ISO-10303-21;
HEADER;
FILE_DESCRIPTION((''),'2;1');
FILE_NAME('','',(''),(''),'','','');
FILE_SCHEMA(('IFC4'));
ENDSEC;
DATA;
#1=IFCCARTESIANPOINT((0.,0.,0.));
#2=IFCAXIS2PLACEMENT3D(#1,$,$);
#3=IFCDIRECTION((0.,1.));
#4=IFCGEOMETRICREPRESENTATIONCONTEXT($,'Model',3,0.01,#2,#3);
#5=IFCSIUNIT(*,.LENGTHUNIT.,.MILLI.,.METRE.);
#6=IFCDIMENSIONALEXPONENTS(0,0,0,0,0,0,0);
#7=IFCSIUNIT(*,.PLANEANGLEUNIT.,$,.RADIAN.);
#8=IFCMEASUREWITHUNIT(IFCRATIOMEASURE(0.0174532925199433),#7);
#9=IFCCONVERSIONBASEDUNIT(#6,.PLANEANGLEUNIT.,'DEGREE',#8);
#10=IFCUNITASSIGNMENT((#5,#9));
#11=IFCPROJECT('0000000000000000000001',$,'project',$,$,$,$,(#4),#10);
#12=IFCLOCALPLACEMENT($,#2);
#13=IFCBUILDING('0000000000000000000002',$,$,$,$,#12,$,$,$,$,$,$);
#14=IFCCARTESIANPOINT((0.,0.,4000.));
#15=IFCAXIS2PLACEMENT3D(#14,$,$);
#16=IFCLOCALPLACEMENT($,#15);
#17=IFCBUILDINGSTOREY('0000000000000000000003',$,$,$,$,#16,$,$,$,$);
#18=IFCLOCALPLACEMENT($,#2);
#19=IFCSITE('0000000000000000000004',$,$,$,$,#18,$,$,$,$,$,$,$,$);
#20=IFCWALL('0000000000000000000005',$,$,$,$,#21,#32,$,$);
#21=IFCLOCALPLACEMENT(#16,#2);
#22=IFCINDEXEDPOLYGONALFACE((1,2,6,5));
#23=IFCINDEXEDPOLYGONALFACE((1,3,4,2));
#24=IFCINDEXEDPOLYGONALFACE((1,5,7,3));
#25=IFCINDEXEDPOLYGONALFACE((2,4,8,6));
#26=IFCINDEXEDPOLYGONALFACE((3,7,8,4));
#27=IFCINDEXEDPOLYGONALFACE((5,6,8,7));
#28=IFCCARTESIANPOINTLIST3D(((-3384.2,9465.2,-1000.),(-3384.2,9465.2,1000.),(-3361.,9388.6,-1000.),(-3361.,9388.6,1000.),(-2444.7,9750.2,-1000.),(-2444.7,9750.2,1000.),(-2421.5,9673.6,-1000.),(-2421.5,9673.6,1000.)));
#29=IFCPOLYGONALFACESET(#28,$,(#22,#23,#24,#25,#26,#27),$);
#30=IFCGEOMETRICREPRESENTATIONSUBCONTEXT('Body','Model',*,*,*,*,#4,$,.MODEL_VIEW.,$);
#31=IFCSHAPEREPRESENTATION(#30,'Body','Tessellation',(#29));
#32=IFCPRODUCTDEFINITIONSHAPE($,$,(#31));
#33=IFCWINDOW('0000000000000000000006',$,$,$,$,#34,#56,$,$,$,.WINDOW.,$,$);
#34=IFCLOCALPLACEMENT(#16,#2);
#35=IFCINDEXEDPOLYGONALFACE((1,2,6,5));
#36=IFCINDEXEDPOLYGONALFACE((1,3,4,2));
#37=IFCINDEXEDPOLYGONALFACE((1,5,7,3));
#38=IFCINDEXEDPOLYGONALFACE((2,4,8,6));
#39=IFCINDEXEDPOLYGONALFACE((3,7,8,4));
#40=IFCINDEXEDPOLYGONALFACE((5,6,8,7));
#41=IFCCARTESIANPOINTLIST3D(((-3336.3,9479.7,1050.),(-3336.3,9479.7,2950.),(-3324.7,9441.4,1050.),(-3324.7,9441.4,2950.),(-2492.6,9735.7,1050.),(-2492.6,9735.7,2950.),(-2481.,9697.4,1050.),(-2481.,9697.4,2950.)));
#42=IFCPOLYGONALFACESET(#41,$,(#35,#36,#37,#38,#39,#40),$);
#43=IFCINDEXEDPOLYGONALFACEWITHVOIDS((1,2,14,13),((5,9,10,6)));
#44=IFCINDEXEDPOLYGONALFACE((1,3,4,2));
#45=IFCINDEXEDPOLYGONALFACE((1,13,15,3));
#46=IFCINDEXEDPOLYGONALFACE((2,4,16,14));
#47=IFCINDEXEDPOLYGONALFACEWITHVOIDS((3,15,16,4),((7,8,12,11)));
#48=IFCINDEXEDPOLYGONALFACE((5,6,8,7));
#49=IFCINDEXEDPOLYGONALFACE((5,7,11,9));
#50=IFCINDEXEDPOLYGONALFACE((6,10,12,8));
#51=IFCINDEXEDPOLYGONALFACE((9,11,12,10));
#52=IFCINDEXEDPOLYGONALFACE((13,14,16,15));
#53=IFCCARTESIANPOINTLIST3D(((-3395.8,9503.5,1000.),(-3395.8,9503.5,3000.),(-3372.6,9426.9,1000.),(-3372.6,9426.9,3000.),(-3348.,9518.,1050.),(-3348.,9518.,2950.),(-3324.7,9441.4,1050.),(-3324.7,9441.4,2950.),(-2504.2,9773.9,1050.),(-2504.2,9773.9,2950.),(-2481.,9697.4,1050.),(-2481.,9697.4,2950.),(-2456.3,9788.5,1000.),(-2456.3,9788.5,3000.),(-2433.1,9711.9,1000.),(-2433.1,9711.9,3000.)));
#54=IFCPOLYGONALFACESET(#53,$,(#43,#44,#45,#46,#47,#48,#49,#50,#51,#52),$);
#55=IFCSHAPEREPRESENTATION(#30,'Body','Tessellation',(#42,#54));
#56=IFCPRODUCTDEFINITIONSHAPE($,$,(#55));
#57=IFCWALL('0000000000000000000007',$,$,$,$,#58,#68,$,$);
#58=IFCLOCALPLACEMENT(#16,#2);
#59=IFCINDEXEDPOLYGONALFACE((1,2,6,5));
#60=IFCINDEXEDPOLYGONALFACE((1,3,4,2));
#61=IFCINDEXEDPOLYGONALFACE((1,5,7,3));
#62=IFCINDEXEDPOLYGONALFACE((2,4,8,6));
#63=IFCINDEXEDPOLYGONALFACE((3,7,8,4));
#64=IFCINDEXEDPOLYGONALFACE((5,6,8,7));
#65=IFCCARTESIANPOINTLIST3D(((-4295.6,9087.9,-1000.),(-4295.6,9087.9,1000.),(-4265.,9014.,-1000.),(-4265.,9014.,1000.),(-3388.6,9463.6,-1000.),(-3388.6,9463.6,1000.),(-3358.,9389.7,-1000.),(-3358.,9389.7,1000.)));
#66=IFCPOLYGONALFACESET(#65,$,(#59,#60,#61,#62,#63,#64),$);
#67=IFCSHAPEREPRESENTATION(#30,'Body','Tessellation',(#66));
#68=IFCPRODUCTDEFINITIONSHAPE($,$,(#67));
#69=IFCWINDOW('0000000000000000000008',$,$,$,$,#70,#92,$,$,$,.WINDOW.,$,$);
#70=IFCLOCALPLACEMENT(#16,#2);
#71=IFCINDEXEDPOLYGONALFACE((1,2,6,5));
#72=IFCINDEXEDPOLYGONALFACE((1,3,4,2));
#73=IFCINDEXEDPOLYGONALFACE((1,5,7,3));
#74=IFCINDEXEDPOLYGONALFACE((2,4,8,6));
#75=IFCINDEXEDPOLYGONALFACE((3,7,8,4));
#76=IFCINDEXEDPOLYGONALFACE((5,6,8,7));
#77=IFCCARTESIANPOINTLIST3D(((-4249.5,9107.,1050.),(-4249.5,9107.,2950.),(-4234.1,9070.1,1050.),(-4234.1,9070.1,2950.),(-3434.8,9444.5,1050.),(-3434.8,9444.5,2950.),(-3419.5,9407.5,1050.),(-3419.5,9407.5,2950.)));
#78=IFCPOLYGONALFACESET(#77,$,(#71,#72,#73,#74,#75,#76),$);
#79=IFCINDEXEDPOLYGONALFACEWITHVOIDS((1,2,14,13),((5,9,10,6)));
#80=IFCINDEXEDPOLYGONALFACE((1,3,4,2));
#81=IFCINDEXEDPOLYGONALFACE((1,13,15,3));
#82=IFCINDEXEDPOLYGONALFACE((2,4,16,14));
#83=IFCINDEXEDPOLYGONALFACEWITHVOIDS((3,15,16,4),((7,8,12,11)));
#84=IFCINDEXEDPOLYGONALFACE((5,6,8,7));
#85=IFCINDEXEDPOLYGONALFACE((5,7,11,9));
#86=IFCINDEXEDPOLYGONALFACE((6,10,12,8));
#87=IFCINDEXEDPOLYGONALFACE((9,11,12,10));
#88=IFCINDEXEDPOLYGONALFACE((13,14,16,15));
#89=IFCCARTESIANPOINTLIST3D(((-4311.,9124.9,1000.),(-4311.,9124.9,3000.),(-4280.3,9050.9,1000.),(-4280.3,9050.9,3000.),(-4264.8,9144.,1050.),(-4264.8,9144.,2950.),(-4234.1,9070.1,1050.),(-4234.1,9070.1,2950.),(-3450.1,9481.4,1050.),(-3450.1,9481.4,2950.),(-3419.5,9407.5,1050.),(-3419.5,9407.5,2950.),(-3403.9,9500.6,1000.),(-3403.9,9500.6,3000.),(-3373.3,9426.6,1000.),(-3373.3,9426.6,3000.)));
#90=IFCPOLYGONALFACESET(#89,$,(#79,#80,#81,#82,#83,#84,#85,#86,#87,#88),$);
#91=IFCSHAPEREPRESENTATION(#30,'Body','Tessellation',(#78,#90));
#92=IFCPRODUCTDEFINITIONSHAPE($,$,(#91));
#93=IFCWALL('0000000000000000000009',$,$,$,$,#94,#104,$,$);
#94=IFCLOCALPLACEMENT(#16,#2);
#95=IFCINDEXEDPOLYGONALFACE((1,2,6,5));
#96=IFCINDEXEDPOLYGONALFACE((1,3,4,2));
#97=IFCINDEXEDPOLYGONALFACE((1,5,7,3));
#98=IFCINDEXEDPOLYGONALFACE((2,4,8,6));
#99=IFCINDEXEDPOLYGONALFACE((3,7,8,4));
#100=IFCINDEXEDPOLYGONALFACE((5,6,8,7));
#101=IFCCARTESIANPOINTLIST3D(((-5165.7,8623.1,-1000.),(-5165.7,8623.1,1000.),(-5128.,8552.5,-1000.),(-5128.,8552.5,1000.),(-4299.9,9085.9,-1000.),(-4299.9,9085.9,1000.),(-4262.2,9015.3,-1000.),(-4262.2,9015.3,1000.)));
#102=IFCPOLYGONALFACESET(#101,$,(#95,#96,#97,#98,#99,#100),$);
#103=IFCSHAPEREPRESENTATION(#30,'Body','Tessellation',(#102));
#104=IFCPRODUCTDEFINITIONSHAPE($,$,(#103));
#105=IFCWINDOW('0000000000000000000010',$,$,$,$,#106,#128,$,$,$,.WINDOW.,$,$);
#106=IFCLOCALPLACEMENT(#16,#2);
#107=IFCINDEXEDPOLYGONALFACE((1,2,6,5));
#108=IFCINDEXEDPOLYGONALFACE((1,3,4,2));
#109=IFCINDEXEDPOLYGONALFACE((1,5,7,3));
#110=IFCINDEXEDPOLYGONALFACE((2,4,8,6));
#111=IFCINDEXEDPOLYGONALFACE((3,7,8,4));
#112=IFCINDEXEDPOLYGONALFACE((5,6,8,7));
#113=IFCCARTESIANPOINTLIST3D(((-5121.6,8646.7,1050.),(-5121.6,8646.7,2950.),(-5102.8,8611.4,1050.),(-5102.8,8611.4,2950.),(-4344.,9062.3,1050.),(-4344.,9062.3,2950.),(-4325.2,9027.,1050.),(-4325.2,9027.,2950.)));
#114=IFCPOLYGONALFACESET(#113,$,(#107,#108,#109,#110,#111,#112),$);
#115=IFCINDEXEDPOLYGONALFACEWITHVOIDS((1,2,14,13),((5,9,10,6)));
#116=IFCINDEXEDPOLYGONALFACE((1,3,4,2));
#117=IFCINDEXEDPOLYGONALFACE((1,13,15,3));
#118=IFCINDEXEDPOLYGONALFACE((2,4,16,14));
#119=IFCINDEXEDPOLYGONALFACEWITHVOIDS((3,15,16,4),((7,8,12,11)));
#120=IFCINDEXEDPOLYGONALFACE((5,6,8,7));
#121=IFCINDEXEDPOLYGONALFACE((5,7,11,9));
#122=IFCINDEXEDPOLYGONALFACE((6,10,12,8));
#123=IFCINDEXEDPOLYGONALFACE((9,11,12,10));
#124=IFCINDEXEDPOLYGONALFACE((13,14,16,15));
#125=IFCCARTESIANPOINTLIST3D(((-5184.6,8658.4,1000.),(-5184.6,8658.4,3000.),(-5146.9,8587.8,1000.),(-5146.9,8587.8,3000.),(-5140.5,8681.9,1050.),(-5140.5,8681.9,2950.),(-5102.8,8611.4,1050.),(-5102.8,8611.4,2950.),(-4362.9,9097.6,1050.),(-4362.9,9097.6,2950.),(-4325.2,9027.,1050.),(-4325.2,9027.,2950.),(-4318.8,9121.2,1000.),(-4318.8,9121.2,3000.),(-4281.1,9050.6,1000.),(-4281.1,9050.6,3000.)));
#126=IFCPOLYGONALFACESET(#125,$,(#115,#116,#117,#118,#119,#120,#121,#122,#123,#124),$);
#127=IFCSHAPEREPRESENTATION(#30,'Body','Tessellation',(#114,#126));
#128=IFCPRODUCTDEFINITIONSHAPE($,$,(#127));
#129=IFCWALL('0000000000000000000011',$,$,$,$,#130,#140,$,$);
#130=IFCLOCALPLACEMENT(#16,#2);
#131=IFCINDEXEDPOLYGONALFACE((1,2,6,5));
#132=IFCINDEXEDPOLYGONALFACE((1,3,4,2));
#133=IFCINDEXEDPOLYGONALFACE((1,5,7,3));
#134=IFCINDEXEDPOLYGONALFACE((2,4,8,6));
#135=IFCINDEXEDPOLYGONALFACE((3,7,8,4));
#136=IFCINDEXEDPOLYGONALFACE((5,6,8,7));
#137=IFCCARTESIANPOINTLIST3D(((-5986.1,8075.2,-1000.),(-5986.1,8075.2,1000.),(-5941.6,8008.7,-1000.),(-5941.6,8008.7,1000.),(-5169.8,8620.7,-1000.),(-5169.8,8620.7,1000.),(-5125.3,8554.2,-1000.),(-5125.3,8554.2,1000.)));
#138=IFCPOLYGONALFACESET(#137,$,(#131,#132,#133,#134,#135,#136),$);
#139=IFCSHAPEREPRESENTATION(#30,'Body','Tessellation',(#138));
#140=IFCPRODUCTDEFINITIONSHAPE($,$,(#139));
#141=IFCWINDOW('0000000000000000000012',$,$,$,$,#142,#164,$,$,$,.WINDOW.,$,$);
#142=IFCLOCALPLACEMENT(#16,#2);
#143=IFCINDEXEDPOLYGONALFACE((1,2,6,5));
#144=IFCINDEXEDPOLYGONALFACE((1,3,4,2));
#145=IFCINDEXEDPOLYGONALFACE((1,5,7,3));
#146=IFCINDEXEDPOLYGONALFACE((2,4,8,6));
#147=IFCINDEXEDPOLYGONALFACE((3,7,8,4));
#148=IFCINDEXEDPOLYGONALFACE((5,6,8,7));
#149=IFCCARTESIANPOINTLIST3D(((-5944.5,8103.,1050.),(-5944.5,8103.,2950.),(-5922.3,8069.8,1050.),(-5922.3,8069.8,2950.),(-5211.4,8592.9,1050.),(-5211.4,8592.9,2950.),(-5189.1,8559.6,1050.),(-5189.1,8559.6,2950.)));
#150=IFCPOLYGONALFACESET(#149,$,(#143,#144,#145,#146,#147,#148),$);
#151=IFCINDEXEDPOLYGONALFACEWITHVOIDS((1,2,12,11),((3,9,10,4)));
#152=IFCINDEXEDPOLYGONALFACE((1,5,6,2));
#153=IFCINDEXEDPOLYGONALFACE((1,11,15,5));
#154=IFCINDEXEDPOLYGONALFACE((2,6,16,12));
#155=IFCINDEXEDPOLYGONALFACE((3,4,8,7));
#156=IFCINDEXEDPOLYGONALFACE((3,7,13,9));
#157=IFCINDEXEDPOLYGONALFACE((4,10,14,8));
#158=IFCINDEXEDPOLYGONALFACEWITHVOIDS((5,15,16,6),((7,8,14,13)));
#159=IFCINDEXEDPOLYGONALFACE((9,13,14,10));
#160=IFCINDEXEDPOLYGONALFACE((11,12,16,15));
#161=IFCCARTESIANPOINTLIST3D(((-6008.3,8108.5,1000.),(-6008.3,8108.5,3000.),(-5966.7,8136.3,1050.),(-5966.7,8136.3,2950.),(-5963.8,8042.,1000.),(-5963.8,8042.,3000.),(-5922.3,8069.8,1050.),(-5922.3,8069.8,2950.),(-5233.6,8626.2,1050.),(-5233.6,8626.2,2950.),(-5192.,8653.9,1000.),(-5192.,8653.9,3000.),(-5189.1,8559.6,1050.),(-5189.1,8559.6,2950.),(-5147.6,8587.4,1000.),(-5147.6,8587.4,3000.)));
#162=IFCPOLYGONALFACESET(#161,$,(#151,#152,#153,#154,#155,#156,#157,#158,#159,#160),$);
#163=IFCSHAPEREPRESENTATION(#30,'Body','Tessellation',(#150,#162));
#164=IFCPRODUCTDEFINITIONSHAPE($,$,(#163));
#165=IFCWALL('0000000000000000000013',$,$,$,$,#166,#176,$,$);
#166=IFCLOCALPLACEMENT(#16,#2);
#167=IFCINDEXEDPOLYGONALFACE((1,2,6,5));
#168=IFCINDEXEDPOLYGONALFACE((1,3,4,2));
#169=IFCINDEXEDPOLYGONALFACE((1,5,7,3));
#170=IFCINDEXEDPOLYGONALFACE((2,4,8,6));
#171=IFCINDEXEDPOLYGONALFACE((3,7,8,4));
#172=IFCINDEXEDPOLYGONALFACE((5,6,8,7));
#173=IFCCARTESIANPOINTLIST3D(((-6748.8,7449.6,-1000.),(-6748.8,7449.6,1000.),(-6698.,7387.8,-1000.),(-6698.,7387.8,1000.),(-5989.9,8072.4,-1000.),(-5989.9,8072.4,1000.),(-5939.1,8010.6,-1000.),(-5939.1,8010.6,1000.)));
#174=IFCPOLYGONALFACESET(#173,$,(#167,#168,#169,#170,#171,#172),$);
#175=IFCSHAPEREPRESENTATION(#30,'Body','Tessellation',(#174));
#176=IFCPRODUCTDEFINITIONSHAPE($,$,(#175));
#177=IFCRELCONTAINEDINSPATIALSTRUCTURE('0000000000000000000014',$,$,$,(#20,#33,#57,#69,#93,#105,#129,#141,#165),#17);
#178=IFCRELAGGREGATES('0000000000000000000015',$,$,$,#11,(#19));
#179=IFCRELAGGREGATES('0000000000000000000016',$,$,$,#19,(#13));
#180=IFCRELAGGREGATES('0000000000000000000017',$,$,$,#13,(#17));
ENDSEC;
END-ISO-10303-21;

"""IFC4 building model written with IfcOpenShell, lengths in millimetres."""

from ifc_helpers import new_model, entity, si_unit, converted_unit, direction, frame, origin, origin_2d, place, context, subcontext, project, spatial, rectangle, extrude, element, save


model = new_model("IFC4")

# Units and contexts
model_context = context("Model", 3, precision=0.01, world=origin(), true_north=direction((0.0, 1.0)))
body_context = subcontext(model_context, "Body", "Model", "MODEL_VIEW")
ifc_project = project(units=[si_unit("LENGTHUNIT", "METRE", prefix="MILLI"), converted_unit("PLANEANGLEUNIT", "DEGREE", entity("IfcRatioMeasure", 0.0174532925199433), si_unit("PLANEANGLEUNIT", "RADIAN"), dimensions=[0, 0, 0, 0, 0, 0, 0])], contexts=[model_context])

# Site, building, storey
site_placement = place(None, origin())
site = spatial("IfcSite", under=ifc_project, at=site_placement)
building_placement = place(None, origin())
building = spatial("IfcBuilding", under=site, at=building_placement)
storey_placement = place(None, frame((0.0, 0.0, 4000.0)))
storey = spatial("IfcBuildingStorey", under=building, at=storey_placement)

# Shared definitions
cartesian_point_1 = entity("IfcCartesianPoint", [-440.9, -950.0])
shared_polyline = entity("IfcPolyline", [cartesian_point_1, entity("IfcCartesianPoint", [-440.9, 950.0]), entity("IfcCartesianPoint", [-440.9, 950.0]), entity("IfcCartesianPoint", [440.9, 950.0]), entity("IfcCartesianPoint", [440.9, 950.0]), entity("IfcCartesianPoint", [440.9, -950.0]), entity("IfcCartesianPoint", [440.9, -950.0]), entity("IfcCartesianPoint", [-440.9, -950.0]), cartesian_point_1])

# Wall
wall_1_placement = place(storey_placement, frame((-2902.8, 9569.4, -1000.0), z_axis=(0.0, 0.0, 1.0), x_axis=(-9569.403228, -2902.847198, 0.0)))
element("IfcWall", 1, at=wall_1_placement, inside=storey, context=body_context, shape_type="SweptSolid", body=[
    extrude(rectangle(XDim=981.7, YDim=80.0, at=origin_2d()), origin(), (0.0, 0.0, 1.0), 2000.0),
])

# Window
window_1_placement = place(storey_placement, frame((-2902.8, 9569.4, 2000.0), z_axis=(0.0, 0.0, 1.0), x_axis=(-9569.403228, -2902.847198, 0.0)))
cartesian_point_2 = entity("IfcCartesianPoint", [-490.9, -1000.0])
element("IfcWindow", 2, at=window_1_placement, inside=storey, PredefinedType="WINDOW", context=body_context, shape_type="SweptSolid", body=[
    entity("IfcExtrudedAreaSolid", entity("IfcArbitraryClosedProfileDef", "AREA", None, shared_polyline), entity("IfcAxis2Placement3D", entity("IfcCartesianPoint", [0.0, 0.0, 0.0]), entity("IfcDirection", [0.0, -1.0, 0.0]), entity("IfcDirection", [1.0, 0.0, 0.0])), entity("IfcDirection", [0.0, 0.0, 1.0]), 40.0),
    entity("IfcExtrudedAreaSolid", entity("IfcArbitraryProfileDefWithVoids", "AREA", None, entity("IfcPolyline", [cartesian_point_2, entity("IfcCartesianPoint", [-490.9, 1000.0]), entity("IfcCartesianPoint", [-490.9, 1000.0]), entity("IfcCartesianPoint", [490.9, 1000.0]), entity("IfcCartesianPoint", [490.9, 1000.0]), entity("IfcCartesianPoint", [490.9, -1000.0]), entity("IfcCartesianPoint", [490.9, -1000.0]), entity("IfcCartesianPoint", [-490.9, -1000.0]), cartesian_point_2]), [shared_polyline]), entity("IfcAxis2Placement3D", entity("IfcCartesianPoint", [0.0, 0.0, 0.0]), entity("IfcDirection", [0.0, -1.0, 0.0]), entity("IfcDirection", [1.0, 0.0, 0.0])), entity("IfcDirection", [0.0, 0.0, 1.0]), 80.0),
])

# Wall
wall_2_placement = place(storey_placement, frame((-3826.8, 9238.8, -1000.0), z_axis=(0.0, 0.0, 1.0), x_axis=(-9238.795458, -3826.834002, 0.0)))
element("IfcWall", 3, at=wall_2_placement, inside=storey, context=body_context, shape_type="SweptSolid", body=[
    extrude(rectangle(XDim=981.7, YDim=80.0, at=origin_2d()), origin(), (0.0, 0.0, 1.0), 2000.0),
])

# Window
window_2_placement = place(storey_placement, frame((-3826.8, 9238.8, 2000.0), z_axis=(0.0, 0.0, 1.0), x_axis=(-9238.795458, -3826.834002, 0.0)))
cartesian_point_3 = entity("IfcCartesianPoint", [-490.9, -1000.0])
element("IfcWindow", 4, at=window_2_placement, inside=storey, PredefinedType="WINDOW", context=body_context, shape_type="SweptSolid", body=[
    entity("IfcExtrudedAreaSolid", entity("IfcArbitraryClosedProfileDef", "AREA", None, shared_polyline), entity("IfcAxis2Placement3D", entity("IfcCartesianPoint", [0.0, 0.0, 0.0]), entity("IfcDirection", [0.0, -1.0, 0.0]), entity("IfcDirection", [1.0, 0.0, 0.0])), entity("IfcDirection", [0.0, 0.0, 1.0]), 40.0),
    entity("IfcExtrudedAreaSolid", entity("IfcArbitraryProfileDefWithVoids", "AREA", None, entity("IfcPolyline", [cartesian_point_3, entity("IfcCartesianPoint", [-490.9, 1000.0]), entity("IfcCartesianPoint", [-490.9, 1000.0]), entity("IfcCartesianPoint", [490.9, 1000.0]), entity("IfcCartesianPoint", [490.9, 1000.0]), entity("IfcCartesianPoint", [490.9, -1000.0]), entity("IfcCartesianPoint", [490.9, -1000.0]), entity("IfcCartesianPoint", [-490.9, -1000.0]), cartesian_point_3]), [shared_polyline]), entity("IfcAxis2Placement3D", entity("IfcCartesianPoint", [0.0, 0.0, 0.0]), entity("IfcDirection", [0.0, -1.0, 0.0]), entity("IfcDirection", [1.0, 0.0, 0.0])), entity("IfcDirection", [0.0, 0.0, 1.0]), 80.0),
])

# Wall
wall_3_placement = place(storey_placement, frame((-4714.0, 8819.2, -1000.0), z_axis=(0.0, 0.0, 1.0), x_axis=(-8819.213181, -4713.966363, 0.0)))
element("IfcWall", 5, at=wall_3_placement, inside=storey, context=body_context, shape_type="SweptSolid", body=[
    extrude(rectangle(XDim=981.7, YDim=80.0, at=origin_2d()), origin(), (0.0, 0.0, 1.0), 2000.0),
])

# Window
window_3_placement = place(storey_placement, frame((-4714.0, 8819.2, 2000.0), z_axis=(0.0, 0.0, 1.0), x_axis=(-8819.213181, -4713.966363, 0.0)))
cartesian_point_4 = entity("IfcCartesianPoint", [-490.9, -1000.0])
element("IfcWindow", 6, at=window_3_placement, inside=storey, PredefinedType="WINDOW", context=body_context, shape_type="SweptSolid", body=[
    entity("IfcExtrudedAreaSolid", entity("IfcArbitraryClosedProfileDef", "AREA", None, shared_polyline), entity("IfcAxis2Placement3D", entity("IfcCartesianPoint", [0.0, 0.0, 0.0]), entity("IfcDirection", [0.0, -1.0, 0.0]), entity("IfcDirection", [1.0, 0.0, 0.0])), entity("IfcDirection", [0.0, 0.0, 1.0]), 40.0),
    entity("IfcExtrudedAreaSolid", entity("IfcArbitraryProfileDefWithVoids", "AREA", None, entity("IfcPolyline", [cartesian_point_4, entity("IfcCartesianPoint", [-490.9, 1000.0]), entity("IfcCartesianPoint", [-490.9, 1000.0]), entity("IfcCartesianPoint", [490.9, 1000.0]), entity("IfcCartesianPoint", [490.9, 1000.0]), entity("IfcCartesianPoint", [490.9, -1000.0]), entity("IfcCartesianPoint", [490.9, -1000.0]), entity("IfcCartesianPoint", [-490.9, -1000.0]), cartesian_point_4]), [shared_polyline]), entity("IfcAxis2Placement3D", entity("IfcCartesianPoint", [0.0, 0.0, 0.0]), entity("IfcDirection", [0.0, -1.0, 0.0]), entity("IfcDirection", [1.0, 0.0, 0.0])), entity("IfcDirection", [0.0, 0.0, 1.0]), 80.0),
])

# Wall
wall_4_placement = place(storey_placement, frame((-5555.7, 8314.7, -1000.0), z_axis=(0.0, 0.0, 1.0), x_axis=(-8314.696534, -5555.701715, 0.0)))
element("IfcWall", 7, at=wall_4_placement, inside=storey, context=body_context, shape_type="SweptSolid", body=[
    extrude(rectangle(XDim=981.7, YDim=80.0, at=origin_2d()), origin(), (0.0, 0.0, 1.0), 2000.0),
])

# Window
window_4_placement = place(storey_placement, frame((-5555.7, 8314.7, 2000.0), z_axis=(0.0, 0.0, 1.0), x_axis=(-8314.696534, -5555.701715, 0.0)))
cartesian_point_5 = entity("IfcCartesianPoint", [-490.9, -1000.0])
element("IfcWindow", 8, at=window_4_placement, inside=storey, PredefinedType="WINDOW", context=body_context, shape_type="SweptSolid", body=[
    entity("IfcExtrudedAreaSolid", entity("IfcArbitraryClosedProfileDef", "AREA", None, shared_polyline), entity("IfcAxis2Placement3D", entity("IfcCartesianPoint", [0.0, 0.0, 0.0]), entity("IfcDirection", [0.0, -1.0, 0.0]), entity("IfcDirection", [1.0, 0.0, 0.0])), entity("IfcDirection", [0.0, 0.0, 1.0]), 40.0),
    entity("IfcExtrudedAreaSolid", entity("IfcArbitraryProfileDefWithVoids", "AREA", None, entity("IfcPolyline", [cartesian_point_5, entity("IfcCartesianPoint", [-490.9, 1000.0]), entity("IfcCartesianPoint", [-490.9, 1000.0]), entity("IfcCartesianPoint", [490.9, 1000.0]), entity("IfcCartesianPoint", [490.9, 1000.0]), entity("IfcCartesianPoint", [490.9, -1000.0]), entity("IfcCartesianPoint", [490.9, -1000.0]), entity("IfcCartesianPoint", [-490.9, -1000.0]), cartesian_point_5]), [shared_polyline]), entity("IfcAxis2Placement3D", entity("IfcCartesianPoint", [0.0, 0.0, 0.0]), entity("IfcDirection", [0.0, -1.0, 0.0]), entity("IfcDirection", [1.0, 0.0, 0.0])), entity("IfcDirection", [0.0, 0.0, 1.0]), 80.0),
])

# Wall
wall_5_placement = place(storey_placement, frame((-6343.9, 7730.1, -1000.0), z_axis=(0.0, 0.0, 1.0), x_axis=(-7730.104749, -6343.932579, 0.0)))
element("IfcWall", 9, at=wall_5_placement, inside=storey, context=body_context, shape_type="SweptSolid", body=[
    extrude(rectangle(XDim=981.7, YDim=80.0, at=origin_2d()), origin(), (0.0, 0.0, 1.0), 2000.0),
])

save(model, "model.ifc")
